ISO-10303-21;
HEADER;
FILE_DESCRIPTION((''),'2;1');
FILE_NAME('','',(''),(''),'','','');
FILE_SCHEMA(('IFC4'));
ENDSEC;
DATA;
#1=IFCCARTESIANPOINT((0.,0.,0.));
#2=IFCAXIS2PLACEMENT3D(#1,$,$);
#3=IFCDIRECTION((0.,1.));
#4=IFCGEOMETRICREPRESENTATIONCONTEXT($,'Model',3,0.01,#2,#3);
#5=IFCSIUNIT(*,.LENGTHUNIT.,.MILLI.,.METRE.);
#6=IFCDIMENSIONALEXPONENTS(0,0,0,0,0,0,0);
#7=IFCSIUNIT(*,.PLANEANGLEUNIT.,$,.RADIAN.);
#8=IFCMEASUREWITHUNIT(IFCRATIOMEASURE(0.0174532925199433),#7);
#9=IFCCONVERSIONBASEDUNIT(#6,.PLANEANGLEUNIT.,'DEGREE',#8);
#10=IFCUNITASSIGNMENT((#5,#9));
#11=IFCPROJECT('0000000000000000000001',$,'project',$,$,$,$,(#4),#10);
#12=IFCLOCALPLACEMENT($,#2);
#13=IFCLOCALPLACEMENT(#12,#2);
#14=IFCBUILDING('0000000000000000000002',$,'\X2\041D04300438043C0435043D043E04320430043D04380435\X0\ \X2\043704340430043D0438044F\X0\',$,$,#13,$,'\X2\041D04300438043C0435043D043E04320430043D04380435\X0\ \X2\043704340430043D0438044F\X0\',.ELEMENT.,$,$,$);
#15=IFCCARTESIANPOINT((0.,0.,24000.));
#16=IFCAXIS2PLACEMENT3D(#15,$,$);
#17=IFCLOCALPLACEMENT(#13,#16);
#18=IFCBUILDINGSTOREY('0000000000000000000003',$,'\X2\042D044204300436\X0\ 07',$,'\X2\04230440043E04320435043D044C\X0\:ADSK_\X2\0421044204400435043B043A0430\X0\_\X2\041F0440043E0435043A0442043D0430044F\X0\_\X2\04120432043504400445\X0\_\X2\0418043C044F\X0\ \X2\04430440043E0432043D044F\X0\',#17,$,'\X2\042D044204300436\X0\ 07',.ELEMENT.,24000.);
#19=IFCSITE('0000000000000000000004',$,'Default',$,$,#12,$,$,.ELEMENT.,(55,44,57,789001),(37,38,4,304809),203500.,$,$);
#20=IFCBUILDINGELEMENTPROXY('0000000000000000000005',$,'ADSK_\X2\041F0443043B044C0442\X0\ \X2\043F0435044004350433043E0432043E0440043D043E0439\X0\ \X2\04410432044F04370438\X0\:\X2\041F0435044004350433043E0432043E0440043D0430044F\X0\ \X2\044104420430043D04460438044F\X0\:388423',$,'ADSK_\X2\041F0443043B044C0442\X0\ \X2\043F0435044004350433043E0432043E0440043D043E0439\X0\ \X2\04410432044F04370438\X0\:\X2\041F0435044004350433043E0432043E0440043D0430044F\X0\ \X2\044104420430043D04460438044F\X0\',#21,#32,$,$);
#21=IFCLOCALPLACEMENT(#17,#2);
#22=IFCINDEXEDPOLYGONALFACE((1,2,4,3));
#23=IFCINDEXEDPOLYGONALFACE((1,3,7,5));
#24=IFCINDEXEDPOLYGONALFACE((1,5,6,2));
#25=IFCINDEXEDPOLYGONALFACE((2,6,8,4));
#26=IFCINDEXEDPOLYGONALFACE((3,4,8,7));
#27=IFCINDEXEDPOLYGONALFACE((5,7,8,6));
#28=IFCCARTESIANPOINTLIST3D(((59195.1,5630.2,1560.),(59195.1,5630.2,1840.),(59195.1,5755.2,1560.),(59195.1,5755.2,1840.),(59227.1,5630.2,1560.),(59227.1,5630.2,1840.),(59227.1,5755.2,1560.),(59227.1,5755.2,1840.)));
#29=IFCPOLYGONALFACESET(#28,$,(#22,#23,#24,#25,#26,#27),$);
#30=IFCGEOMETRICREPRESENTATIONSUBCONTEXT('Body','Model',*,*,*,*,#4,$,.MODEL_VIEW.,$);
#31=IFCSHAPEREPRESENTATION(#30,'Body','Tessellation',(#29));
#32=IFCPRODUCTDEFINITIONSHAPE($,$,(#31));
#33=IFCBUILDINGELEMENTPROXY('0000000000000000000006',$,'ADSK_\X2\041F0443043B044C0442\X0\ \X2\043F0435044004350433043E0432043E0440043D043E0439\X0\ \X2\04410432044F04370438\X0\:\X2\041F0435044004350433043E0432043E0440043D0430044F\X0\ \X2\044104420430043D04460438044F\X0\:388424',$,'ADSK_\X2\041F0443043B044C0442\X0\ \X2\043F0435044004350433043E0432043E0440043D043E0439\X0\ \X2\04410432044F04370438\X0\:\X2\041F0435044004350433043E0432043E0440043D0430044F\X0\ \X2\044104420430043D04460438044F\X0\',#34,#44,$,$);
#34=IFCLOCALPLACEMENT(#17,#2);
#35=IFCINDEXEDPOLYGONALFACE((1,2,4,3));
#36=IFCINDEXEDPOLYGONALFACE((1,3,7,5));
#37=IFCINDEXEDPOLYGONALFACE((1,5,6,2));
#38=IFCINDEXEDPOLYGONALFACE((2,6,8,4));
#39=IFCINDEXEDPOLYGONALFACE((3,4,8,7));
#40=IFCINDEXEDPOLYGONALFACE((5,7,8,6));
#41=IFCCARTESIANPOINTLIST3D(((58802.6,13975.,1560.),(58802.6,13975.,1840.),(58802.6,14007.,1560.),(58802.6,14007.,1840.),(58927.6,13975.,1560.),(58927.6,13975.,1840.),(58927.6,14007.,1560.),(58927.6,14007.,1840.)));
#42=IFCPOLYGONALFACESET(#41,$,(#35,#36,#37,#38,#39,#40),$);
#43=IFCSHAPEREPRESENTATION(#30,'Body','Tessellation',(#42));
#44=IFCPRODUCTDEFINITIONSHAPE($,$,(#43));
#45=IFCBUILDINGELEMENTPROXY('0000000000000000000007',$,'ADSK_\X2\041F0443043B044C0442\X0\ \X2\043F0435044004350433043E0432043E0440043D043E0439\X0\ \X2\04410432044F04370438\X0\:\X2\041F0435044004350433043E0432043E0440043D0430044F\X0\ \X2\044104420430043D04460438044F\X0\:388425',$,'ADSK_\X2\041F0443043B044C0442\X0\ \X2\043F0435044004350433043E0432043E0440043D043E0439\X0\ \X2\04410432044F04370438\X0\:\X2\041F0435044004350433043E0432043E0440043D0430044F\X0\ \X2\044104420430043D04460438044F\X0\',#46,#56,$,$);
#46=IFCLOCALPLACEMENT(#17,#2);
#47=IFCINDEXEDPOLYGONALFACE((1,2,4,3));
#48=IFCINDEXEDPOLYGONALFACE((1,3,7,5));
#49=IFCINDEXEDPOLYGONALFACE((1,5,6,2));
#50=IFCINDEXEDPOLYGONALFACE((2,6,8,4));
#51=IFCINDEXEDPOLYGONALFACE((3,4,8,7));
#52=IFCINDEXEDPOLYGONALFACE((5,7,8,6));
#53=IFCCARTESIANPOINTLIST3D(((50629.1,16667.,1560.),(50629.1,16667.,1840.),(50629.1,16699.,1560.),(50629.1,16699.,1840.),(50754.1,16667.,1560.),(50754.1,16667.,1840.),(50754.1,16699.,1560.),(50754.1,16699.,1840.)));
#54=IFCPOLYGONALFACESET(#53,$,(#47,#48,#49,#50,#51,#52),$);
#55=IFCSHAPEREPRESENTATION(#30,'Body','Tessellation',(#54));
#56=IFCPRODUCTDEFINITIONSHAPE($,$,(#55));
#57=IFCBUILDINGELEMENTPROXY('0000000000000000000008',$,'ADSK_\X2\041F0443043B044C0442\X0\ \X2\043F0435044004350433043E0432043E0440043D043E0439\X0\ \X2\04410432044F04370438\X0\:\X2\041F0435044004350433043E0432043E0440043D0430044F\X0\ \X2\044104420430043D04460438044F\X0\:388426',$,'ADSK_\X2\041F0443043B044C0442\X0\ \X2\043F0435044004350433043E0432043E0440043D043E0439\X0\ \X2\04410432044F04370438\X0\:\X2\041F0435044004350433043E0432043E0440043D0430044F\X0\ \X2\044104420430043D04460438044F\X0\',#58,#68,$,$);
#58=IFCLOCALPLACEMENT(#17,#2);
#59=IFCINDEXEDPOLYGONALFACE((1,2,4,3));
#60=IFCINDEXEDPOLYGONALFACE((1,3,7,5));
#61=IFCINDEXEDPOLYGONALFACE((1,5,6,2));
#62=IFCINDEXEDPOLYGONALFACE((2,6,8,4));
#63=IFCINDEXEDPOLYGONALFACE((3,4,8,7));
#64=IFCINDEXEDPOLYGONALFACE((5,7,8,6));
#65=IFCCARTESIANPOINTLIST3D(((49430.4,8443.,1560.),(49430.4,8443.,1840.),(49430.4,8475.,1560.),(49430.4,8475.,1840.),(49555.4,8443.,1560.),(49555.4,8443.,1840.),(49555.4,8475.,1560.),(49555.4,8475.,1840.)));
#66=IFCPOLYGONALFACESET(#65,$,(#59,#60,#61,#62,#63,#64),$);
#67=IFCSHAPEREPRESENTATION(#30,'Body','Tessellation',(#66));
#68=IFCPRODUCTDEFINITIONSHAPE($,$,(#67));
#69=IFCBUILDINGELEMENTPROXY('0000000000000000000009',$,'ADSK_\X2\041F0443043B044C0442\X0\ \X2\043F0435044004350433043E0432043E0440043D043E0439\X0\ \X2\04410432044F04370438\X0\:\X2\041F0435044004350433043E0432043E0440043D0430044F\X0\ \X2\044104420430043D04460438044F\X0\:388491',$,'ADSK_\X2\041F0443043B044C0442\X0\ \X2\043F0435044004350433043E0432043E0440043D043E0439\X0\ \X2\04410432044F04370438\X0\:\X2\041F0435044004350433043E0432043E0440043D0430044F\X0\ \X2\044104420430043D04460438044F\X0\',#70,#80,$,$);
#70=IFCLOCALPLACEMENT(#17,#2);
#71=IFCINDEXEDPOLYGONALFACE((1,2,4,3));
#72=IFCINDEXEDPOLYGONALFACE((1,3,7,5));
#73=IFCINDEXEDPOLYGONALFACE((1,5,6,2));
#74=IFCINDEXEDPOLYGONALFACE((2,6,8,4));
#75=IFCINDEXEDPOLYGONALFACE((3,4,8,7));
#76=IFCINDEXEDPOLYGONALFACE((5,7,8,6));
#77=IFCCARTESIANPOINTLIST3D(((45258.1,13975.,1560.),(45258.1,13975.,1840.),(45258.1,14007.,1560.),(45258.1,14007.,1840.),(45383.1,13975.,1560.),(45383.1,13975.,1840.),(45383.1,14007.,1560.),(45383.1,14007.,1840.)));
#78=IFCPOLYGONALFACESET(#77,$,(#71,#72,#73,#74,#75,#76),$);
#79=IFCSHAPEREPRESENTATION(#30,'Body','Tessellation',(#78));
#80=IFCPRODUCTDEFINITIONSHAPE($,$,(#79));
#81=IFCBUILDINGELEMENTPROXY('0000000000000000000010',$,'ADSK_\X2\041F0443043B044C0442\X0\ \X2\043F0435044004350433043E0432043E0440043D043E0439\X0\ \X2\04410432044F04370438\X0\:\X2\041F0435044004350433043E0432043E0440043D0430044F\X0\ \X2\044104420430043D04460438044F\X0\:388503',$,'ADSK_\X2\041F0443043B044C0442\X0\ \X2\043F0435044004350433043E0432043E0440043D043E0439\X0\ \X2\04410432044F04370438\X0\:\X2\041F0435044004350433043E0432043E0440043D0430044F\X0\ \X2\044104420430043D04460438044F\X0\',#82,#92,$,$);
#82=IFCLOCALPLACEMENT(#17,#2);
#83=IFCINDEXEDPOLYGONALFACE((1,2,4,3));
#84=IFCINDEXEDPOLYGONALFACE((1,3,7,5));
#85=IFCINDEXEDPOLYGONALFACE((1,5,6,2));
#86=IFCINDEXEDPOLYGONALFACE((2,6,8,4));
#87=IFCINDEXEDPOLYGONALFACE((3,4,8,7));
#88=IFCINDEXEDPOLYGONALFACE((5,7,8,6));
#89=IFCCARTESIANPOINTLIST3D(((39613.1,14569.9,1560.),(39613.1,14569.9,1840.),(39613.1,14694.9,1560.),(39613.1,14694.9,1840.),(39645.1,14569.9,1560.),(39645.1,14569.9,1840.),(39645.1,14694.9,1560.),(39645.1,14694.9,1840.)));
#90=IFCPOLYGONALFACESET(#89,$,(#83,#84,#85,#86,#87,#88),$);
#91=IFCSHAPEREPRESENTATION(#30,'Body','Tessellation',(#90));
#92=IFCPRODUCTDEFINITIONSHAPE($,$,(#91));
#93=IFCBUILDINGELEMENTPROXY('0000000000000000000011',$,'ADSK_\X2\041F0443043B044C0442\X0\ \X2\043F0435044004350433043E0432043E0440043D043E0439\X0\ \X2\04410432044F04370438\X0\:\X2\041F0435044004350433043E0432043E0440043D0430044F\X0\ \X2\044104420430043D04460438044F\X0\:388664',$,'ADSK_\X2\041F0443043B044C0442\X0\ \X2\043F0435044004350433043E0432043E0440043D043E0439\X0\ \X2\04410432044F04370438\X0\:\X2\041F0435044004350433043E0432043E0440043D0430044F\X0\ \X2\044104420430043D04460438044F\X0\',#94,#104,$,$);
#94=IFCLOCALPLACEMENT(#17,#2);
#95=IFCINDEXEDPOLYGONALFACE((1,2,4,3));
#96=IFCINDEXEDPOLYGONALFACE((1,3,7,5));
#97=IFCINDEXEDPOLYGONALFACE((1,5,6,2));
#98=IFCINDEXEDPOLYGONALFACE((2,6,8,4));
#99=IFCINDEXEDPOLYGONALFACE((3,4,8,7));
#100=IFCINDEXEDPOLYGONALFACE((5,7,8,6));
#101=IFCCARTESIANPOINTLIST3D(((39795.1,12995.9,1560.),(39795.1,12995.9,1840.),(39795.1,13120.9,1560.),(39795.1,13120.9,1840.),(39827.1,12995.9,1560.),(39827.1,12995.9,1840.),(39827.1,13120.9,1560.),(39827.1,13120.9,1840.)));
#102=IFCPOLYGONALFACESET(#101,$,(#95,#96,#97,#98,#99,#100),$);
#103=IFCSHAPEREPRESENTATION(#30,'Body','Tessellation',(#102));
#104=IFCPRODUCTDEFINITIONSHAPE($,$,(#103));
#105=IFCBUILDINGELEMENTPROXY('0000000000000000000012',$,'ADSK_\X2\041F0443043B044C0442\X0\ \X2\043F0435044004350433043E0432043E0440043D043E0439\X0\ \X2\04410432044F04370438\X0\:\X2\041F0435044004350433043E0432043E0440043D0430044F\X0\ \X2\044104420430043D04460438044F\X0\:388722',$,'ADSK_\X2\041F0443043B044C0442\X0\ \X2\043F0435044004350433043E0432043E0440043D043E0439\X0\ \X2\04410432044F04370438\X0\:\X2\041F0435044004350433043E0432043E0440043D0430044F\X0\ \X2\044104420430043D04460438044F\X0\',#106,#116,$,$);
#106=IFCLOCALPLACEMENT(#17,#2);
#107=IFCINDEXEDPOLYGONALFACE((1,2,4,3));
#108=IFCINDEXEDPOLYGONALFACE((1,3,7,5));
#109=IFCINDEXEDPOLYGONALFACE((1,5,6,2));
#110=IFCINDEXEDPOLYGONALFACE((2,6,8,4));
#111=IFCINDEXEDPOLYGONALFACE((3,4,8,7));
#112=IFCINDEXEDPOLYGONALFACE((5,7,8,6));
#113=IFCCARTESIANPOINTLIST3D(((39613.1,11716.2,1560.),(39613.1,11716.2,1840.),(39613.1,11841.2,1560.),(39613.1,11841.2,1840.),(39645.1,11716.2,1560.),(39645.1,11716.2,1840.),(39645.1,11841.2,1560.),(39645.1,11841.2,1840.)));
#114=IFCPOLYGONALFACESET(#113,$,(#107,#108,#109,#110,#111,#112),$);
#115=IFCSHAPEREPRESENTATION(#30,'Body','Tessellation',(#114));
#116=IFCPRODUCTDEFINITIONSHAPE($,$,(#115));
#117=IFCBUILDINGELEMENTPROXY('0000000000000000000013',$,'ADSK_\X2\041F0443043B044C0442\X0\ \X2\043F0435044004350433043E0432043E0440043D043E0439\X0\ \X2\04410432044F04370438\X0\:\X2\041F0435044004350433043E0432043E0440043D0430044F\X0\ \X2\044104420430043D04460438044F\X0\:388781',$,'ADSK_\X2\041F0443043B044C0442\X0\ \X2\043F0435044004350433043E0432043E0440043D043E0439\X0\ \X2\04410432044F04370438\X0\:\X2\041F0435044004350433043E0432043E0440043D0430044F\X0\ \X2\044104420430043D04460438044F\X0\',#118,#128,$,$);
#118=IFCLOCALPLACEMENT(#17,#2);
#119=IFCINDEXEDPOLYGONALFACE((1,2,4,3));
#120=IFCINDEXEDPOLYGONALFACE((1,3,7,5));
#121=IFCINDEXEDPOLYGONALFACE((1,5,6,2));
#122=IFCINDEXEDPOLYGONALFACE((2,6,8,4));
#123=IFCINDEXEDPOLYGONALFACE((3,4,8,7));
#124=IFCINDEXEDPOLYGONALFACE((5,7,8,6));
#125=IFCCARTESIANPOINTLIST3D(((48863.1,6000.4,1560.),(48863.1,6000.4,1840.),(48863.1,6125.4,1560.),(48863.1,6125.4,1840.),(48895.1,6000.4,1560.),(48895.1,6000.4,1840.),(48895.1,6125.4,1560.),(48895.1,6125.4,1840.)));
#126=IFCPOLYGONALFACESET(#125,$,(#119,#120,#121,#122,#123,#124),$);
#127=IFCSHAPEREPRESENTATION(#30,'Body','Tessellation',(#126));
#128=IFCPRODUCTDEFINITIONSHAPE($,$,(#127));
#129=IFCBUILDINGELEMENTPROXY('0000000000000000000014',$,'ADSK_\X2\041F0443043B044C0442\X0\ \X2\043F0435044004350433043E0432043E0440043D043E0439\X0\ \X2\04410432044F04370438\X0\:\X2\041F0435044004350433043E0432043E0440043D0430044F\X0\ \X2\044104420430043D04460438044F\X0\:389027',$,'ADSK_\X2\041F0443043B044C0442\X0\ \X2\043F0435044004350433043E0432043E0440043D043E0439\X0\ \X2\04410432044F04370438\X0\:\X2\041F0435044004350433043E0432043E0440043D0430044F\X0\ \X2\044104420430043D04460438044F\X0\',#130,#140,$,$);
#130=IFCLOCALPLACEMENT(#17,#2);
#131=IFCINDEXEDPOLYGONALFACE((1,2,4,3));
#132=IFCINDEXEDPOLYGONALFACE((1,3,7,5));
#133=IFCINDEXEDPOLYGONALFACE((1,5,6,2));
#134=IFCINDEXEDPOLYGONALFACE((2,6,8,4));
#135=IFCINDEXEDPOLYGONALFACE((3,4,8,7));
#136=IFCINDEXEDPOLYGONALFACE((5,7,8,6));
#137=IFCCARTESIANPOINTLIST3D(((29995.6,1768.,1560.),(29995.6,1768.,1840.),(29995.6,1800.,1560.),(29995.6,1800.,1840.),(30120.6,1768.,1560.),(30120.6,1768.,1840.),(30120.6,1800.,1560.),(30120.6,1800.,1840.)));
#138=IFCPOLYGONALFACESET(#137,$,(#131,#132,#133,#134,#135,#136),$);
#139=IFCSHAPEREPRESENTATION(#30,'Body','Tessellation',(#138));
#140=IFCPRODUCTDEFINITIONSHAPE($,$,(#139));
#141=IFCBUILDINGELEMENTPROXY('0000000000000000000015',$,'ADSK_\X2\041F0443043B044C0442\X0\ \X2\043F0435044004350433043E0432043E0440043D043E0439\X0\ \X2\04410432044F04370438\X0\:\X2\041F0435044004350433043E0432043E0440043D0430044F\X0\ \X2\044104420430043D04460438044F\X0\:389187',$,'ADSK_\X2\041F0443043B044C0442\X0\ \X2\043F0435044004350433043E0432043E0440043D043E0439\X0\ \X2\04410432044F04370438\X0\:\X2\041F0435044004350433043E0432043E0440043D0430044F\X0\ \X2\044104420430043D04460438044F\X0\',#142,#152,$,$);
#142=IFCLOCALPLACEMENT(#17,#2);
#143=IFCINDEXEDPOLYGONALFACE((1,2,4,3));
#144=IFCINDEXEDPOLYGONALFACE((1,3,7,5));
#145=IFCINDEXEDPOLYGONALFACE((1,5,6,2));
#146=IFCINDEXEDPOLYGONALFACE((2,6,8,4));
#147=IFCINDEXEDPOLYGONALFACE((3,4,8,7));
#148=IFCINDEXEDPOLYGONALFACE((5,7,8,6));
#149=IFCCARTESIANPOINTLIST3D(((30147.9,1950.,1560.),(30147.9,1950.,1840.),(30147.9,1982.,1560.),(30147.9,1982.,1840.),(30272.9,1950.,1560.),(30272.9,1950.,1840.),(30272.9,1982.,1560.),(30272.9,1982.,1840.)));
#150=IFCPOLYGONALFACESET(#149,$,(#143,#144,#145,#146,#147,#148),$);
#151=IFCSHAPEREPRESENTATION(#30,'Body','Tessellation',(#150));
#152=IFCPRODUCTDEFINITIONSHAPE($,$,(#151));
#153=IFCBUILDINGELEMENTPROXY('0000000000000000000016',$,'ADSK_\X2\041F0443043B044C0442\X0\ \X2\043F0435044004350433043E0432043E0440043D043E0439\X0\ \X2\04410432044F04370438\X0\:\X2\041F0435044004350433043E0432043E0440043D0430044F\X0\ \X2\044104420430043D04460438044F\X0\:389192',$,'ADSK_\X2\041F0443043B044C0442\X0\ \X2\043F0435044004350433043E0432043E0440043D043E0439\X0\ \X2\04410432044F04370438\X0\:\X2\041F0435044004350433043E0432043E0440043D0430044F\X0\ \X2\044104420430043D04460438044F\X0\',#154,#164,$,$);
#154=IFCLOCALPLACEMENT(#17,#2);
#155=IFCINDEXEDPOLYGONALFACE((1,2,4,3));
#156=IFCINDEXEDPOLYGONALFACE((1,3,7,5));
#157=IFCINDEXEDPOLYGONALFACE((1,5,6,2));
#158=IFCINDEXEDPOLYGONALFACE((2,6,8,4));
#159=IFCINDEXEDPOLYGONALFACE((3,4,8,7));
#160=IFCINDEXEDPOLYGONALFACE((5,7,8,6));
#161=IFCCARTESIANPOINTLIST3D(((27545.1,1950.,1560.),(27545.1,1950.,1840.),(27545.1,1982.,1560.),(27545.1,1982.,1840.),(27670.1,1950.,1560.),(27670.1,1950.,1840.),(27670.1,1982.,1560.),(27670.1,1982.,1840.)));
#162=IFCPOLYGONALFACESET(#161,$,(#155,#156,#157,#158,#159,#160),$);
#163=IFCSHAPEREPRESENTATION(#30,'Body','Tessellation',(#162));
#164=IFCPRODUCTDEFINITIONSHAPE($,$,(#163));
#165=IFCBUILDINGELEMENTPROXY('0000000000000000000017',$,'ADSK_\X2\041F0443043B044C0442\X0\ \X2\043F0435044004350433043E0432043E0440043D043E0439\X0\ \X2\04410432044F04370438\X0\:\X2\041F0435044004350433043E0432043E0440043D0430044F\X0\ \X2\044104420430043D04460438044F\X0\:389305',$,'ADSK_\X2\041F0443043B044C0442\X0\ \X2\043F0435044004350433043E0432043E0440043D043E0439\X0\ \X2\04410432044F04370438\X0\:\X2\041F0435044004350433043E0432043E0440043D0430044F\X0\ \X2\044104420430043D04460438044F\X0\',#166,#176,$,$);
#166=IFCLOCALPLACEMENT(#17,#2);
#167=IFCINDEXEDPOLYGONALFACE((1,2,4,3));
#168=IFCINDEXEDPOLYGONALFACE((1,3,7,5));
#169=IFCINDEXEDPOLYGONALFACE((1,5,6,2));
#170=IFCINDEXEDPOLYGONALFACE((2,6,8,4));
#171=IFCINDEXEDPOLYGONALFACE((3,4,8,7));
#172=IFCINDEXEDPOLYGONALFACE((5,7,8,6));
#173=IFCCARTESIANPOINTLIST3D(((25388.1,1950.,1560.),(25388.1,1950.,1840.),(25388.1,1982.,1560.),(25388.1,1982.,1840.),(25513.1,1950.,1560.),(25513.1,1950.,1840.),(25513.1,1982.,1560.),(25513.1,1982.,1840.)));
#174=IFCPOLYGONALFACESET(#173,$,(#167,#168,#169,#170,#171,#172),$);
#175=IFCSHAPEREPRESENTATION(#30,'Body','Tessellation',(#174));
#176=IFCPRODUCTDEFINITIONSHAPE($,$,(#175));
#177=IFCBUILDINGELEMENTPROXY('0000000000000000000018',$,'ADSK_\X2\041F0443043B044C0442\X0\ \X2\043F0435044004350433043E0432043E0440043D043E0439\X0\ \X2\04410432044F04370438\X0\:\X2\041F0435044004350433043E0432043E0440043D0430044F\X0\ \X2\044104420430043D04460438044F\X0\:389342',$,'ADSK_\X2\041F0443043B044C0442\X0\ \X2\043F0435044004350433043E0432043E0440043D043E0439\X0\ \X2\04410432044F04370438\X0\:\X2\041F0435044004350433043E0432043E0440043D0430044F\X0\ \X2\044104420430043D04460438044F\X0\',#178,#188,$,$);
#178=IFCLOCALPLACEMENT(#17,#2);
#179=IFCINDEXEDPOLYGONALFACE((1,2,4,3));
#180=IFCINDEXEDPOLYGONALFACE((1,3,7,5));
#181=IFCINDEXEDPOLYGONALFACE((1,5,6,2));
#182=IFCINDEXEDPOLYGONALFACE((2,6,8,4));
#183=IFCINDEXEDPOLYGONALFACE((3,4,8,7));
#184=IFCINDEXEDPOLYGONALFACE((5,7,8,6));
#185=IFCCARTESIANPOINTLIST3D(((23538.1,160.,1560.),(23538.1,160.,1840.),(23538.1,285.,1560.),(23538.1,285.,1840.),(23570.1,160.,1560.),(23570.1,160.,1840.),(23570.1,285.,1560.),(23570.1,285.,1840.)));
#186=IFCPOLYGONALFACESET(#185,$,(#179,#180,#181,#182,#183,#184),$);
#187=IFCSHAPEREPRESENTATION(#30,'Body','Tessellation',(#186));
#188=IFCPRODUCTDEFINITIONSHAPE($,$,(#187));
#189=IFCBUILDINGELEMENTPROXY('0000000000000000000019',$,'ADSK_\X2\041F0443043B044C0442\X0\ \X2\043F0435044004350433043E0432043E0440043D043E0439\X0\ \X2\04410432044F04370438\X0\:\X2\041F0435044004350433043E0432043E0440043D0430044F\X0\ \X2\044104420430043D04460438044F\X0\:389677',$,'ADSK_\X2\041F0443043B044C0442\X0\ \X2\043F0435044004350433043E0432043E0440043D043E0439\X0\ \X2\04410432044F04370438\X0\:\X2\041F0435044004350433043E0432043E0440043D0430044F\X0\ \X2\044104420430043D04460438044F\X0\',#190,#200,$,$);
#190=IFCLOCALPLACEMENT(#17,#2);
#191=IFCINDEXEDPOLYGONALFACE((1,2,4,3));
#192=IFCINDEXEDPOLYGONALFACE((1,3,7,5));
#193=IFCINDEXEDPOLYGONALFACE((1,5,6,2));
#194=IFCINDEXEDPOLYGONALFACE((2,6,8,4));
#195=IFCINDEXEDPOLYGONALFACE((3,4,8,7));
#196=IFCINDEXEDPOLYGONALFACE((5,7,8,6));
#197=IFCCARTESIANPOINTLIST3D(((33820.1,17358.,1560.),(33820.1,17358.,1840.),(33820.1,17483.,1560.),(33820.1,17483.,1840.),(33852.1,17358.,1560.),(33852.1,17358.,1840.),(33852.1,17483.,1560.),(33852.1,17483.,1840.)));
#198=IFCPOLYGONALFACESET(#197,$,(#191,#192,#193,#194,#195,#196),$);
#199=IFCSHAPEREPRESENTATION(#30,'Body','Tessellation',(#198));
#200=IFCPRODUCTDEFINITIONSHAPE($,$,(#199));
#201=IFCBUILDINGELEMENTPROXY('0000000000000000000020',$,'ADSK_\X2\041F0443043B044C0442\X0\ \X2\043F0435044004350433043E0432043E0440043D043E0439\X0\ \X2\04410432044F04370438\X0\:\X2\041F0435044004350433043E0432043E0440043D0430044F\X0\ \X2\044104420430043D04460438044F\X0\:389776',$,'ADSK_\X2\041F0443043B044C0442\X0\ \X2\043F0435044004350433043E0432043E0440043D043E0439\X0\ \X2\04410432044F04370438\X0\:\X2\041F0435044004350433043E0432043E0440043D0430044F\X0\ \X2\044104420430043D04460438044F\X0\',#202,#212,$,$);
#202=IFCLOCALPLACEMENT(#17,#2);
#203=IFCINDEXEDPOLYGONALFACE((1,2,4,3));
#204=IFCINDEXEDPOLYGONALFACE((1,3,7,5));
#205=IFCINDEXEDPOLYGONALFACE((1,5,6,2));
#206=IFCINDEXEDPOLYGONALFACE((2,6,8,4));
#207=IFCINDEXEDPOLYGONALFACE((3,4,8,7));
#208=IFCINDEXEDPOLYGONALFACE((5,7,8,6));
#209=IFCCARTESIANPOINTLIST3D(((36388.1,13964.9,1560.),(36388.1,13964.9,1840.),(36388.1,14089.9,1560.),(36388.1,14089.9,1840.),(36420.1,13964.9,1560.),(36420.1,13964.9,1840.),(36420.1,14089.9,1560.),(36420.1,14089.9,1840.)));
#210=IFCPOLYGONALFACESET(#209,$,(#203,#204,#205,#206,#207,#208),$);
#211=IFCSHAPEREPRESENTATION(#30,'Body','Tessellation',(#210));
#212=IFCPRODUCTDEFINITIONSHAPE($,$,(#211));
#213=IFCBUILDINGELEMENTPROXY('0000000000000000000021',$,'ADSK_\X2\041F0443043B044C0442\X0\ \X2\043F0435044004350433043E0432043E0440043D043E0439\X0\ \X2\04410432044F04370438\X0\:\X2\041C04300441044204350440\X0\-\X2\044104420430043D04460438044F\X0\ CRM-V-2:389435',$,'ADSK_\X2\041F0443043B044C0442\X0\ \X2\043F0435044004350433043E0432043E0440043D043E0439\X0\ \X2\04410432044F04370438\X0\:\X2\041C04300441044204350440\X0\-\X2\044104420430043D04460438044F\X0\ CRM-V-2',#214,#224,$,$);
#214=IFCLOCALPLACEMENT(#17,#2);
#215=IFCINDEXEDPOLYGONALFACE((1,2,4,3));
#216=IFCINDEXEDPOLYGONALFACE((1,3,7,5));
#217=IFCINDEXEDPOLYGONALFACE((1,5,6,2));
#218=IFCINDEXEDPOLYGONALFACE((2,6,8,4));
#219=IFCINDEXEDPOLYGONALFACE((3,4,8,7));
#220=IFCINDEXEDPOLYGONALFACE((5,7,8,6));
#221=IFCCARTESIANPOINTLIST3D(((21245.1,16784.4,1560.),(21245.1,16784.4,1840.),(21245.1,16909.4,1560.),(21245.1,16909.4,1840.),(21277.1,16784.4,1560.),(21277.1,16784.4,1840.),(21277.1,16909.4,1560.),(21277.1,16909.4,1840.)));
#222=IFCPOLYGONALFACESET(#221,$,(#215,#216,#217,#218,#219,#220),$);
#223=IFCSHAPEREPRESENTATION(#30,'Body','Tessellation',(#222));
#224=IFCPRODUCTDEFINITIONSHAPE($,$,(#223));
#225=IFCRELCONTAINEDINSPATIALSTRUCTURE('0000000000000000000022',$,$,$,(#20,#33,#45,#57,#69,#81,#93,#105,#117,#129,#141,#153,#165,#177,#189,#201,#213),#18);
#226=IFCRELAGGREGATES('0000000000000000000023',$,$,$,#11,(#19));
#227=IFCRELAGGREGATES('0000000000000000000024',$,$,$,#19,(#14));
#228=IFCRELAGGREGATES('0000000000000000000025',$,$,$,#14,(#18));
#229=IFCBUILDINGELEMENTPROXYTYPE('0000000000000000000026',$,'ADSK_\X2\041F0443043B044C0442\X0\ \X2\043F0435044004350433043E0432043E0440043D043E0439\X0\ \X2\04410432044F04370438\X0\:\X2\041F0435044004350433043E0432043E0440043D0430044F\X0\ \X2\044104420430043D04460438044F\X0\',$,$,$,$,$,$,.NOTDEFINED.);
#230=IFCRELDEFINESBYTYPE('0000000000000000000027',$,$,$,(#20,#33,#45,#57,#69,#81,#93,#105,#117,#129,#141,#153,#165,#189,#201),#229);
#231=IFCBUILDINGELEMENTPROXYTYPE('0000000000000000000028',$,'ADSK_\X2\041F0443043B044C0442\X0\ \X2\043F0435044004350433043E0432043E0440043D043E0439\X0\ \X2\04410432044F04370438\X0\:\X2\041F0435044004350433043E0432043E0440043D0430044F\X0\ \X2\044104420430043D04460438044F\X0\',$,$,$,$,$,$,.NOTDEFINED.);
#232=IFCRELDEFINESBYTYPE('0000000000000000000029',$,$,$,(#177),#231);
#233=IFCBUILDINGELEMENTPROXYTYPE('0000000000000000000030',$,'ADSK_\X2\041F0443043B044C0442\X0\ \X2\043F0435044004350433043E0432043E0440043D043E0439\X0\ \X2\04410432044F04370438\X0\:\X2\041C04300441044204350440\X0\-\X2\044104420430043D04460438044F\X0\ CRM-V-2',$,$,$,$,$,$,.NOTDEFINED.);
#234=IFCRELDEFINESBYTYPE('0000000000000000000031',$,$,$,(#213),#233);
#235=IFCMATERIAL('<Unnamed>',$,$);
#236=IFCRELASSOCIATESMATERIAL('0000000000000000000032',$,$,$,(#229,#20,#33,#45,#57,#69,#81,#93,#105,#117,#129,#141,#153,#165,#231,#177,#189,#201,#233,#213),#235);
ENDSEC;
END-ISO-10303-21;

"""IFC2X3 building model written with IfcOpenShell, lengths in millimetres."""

from ifc_helpers import new_model, entity, si_unit, converted_unit, direction, frame, origin, origin_2d_with_axis, place, context, subcontext, project, spatial, rectangle, extrude, source, transform, mapped, material, type_object, type_shapes, element, save


model = new_model("IFC2X3")

# Units and contexts
model_context = context("Model", 3, precision=0.01, world=origin(), true_north=direction((0.0, 1.0)))
body_context = subcontext(model_context, "Body", "Model", "MODEL_VIEW")
ifc_project = project(units=[si_unit("LENGTHUNIT", "METRE", prefix="MILLI"), converted_unit("PLANEANGLEUNIT", "DEGREE", entity("IfcRatioMeasure", 0.0174532925199433), si_unit("PLANEANGLEUNIT", "RADIAN"), dimensions=[0, 0, 0, 0, 0, 0, 0])], contexts=[model_context])

# Site, building, storey
site_placement = place(None, origin())
site = spatial("IfcSite", under=ifc_project, at=site_placement, Name="Default", CompositionType="ELEMENT", RefLatitude=(55, 44, 57, 789001), RefLongitude=(37, 38, 4, 304809), RefElevation=203500.0)
building_placement = place(site_placement, origin())
building = spatial("IfcBuilding", under=site, at=building_placement, Name="Наименование здания", LongName="Наименование здания", CompositionType="ELEMENT")
storey_placement = place(building_placement, frame((0.0, 0.0, 24000.0)))
storey = spatial("IfcBuildingStorey", under=building, at=storey_placement, Name="Этаж 07", ObjectType="Уровень:ADSK_Стрелка_Проектная_Вверх_Имя уровня", LongName="Этаж 07", CompositionType="ELEMENT", Elevation=24000.0)

# Building element proxies
ifc_material_1 = material(Name="<Unnamed>")
building_element_proxy_type_1 = type_object("IfcBuildingElementProxyType", Name="ADSK_Пульт переговорной связи:Переговорная станция", PredefinedType="NOTDEFINED", material=ifc_material_1)
shared_shape_1 = source(origin(), body_context, "Body", "SweptSolid", [
    extrude(rectangle(XDim=125.0, YDim=32.0, at=origin_2d_with_axis()), frame((0.0, 16.0, -140.0), z_axis=(0.0, 0.0, 1.0), x_axis=(-1.0, 0.0, 0.0)), (0.0, 0.0, 1.0), 280.0),
])
type_shapes(building_element_proxy_type_1, [shared_shape_1])
for number, where, z_axis, x_axis, name in (
    (1, (59227.1, 5692.7, 1700.0), (0.0, 0.0, 1.0), (0.0, 1.0, 0.0), "ADSK_Пульт переговорной связи:Переговорная станция:388423"),
    (2, (58865.1, 14007.0, 1700.0), (0.0, 0.0, 1.0), (-1.0, 0.0, 0.0), "ADSK_Пульт переговорной связи:Переговорная станция:388424"),
):
    element("IfcBuildingElementProxy", number, at=place(storey_placement, frame(where, z_axis=z_axis, x_axis=x_axis)), inside=storey, type_object=building_element_proxy_type_1, material=ifc_material_1, Name=name, ObjectType="ADSK_Пульт переговорной связи:Переговорная станция", context=body_context, shape_type="MappedRepresentation", body=[
        mapped(shared_shape_1, transform((0.0, 0.0, 0.0), scale=1.0)),
    ])
for number, where, name in (
    (3, (50691.6, 16667.0, 1700.0), "ADSK_Пульт переговорной связи:Переговорная станция:388425"),
    (4, (49492.9, 8443.0, 1700.0), "ADSK_Пульт переговорной связи:Переговорная станция:388426"),
):
    element("IfcBuildingElementProxy", number, at=place(storey_placement, frame(where)), inside=storey, type_object=building_element_proxy_type_1, material=ifc_material_1, Name=name, ObjectType="ADSK_Пульт переговорной связи:Переговорная станция", context=body_context, shape_type="MappedRepresentation", body=[
        mapped(shared_shape_1, transform((0.0, 0.0, 0.0), scale=1.0)),
    ])
for number, where, z_axis, x_axis, name in (
    (5, (45320.6, 14007.0, 1700.0), (0.0, 0.0, 1.0), (-1.0, 0.0, 0.0), "ADSK_Пульт переговорной связи:Переговорная станция:388491"),
    (6, (39613.1, 14632.4, 1700.0), (0.0, 0.0, 1.0), (0.0, -1.0, 0.0), "ADSK_Пульт переговорной связи:Переговорная станция:388503"),
    (7, (39827.1, 13058.4, 1700.0), (0.0, 0.0, 1.0), (0.0, 1.0, 0.0), "ADSK_Пульт переговорной связи:Переговорная станция:388664"),
    (8, (39613.1, 11778.7, 1700.0), (0.0, 0.0, 1.0), (0.0, -1.0, 0.0), "ADSK_Пульт переговорной связи:Переговорная станция:388722"),
    (9, (48863.1, 6062.9, 1700.0), (0.0, 0.0, 1.0), (0.0, -1.0, 0.0), "ADSK_Пульт переговорной связи:Переговорная станция:388781"),
):
    element("IfcBuildingElementProxy", number, at=place(storey_placement, frame(where, z_axis=z_axis, x_axis=x_axis)), inside=storey, type_object=building_element_proxy_type_1, material=ifc_material_1, Name=name, ObjectType="ADSK_Пульт переговорной связи:Переговорная станция", context=body_context, shape_type="MappedRepresentation", body=[
        mapped(shared_shape_1, transform((0.0, 0.0, 0.0), scale=1.0)),
    ])
proxy_1_placement = place(storey_placement, frame((30058.1, 1768.0, 1700.0)))
element("IfcBuildingElementProxy", 10, at=proxy_1_placement, inside=storey, type_object=building_element_proxy_type_1, material=ifc_material_1, Name="ADSK_Пульт переговорной связи:Переговорная станция:389027", ObjectType="ADSK_Пульт переговорной связи:Переговорная станция", context=body_context, shape_type="MappedRepresentation", body=[
    mapped(shared_shape_1, transform((0.0, 0.0, 0.0), scale=1.0)),
])
for number, where, z_axis, x_axis, name in (
    (11, (30210.4, 1982.0, 1700.0), (0.0, 0.0, 1.0), (-1.0, 0.0, 0.0), "ADSK_Пульт переговорной связи:Переговорная станция:389187"),
    (12, (27607.6, 1982.0, 1700.0), (0.0, 0.0, 1.0), (-1.0, 0.0, 0.0), "ADSK_Пульт переговорной связи:Переговорная станция:389192"),
    (13, (25450.6, 1982.0, 1700.0), (0.0, 0.0, 1.0), (-1.0, 0.0, 0.0), "ADSK_Пульт переговорной связи:Переговорная станция:389305"),
):
    element("IfcBuildingElementProxy", number, at=place(storey_placement, frame(where, z_axis=z_axis, x_axis=x_axis)), inside=storey, type_object=building_element_proxy_type_1, material=ifc_material_1, Name=name, ObjectType="ADSK_Пульт переговорной связи:Переговорная станция", context=body_context, shape_type="MappedRepresentation", body=[
        mapped(shared_shape_1, transform((0.0, 0.0, 0.0), scale=1.0)),
    ])
building_element_proxy_type_2 = type_object("IfcBuildingElementProxyType", Name="ADSK_Пульт переговорной связи:Переговорная станция", PredefinedType="NOTDEFINED", material=ifc_material_1)
type_shapes(building_element_proxy_type_2, [shared_shape_1])
proxy_2_placement = place(storey_placement, frame((23538.1, 222.5, 1700.0), z_axis=(0.0, 0.0, 1.0), x_axis=(0.0, -1.0, 0.0)))
element("IfcBuildingElementProxy", 14, at=proxy_2_placement, inside=storey, type_object=building_element_proxy_type_2, material=ifc_material_1, Name="ADSK_Пульт переговорной связи:Переговорная станция:389342", ObjectType="ADSK_Пульт переговорной связи:Переговорная станция", context=body_context, shape_type="MappedRepresentation", body=[
    mapped(shared_shape_1, transform((0.0, 0.0, 0.0), scale=1.0)),
])
for number, where, z_axis, x_axis, name in (
    (15, (33852.1, 17420.5, 1700.0), (0.0, 0.0, 1.0), (0.0, 1.0, 0.0), "ADSK_Пульт переговорной связи:Переговорная станция:389677"),
    (16, (36388.1, 14027.4, 1700.0), (0.0, 0.0, 1.0), (0.0, -1.0, 0.0), "ADSK_Пульт переговорной связи:Переговорная станция:389776"),
):
    element("IfcBuildingElementProxy", number, at=place(storey_placement, frame(where, z_axis=z_axis, x_axis=x_axis)), inside=storey, type_object=building_element_proxy_type_1, material=ifc_material_1, Name=name, ObjectType="ADSK_Пульт переговорной связи:Переговорная станция", context=body_context, shape_type="MappedRepresentation", body=[
        mapped(shared_shape_1, transform((0.0, 0.0, 0.0), scale=1.0)),
    ])
building_element_proxy_type_3 = type_object("IfcBuildingElementProxyType", Name="ADSK_Пульт переговорной связи:Мастер-станция CRM-V-2", PredefinedType="NOTDEFINED", material=ifc_material_1)
shared_shape_2 = source(origin(), body_context, "Body", "SweptSolid", [
    extrude(rectangle(XDim=125.0, YDim=32.0, at=origin_2d_with_axis()), frame((0.0, 16.0, -140.0), z_axis=(0.0, 0.0, 1.0), x_axis=(-1.0, 0.0, 0.0)), (0.0, 0.0, 1.0), 280.0),
])
type_shapes(building_element_proxy_type_3, [shared_shape_2])
proxy_3_placement = place(storey_placement, frame((21277.1, 16846.9, 1700.0), z_axis=(0.0, 0.0, 1.0), x_axis=(0.0, 1.0, 0.0)))
element("IfcBuildingElementProxy", 17, at=proxy_3_placement, inside=storey, type_object=building_element_proxy_type_3, material=ifc_material_1, Name="ADSK_Пульт переговорной связи:Мастер-станция CRM-V-2:389435", ObjectType="ADSK_Пульт переговорной связи:Мастер-станция CRM-V-2", context=body_context, shape_type="MappedRepresentation", body=[
    mapped(shared_shape_2, transform((0.0, 0.0, 0.0), scale=1.0)),
])

save(model, "model.ifc")
